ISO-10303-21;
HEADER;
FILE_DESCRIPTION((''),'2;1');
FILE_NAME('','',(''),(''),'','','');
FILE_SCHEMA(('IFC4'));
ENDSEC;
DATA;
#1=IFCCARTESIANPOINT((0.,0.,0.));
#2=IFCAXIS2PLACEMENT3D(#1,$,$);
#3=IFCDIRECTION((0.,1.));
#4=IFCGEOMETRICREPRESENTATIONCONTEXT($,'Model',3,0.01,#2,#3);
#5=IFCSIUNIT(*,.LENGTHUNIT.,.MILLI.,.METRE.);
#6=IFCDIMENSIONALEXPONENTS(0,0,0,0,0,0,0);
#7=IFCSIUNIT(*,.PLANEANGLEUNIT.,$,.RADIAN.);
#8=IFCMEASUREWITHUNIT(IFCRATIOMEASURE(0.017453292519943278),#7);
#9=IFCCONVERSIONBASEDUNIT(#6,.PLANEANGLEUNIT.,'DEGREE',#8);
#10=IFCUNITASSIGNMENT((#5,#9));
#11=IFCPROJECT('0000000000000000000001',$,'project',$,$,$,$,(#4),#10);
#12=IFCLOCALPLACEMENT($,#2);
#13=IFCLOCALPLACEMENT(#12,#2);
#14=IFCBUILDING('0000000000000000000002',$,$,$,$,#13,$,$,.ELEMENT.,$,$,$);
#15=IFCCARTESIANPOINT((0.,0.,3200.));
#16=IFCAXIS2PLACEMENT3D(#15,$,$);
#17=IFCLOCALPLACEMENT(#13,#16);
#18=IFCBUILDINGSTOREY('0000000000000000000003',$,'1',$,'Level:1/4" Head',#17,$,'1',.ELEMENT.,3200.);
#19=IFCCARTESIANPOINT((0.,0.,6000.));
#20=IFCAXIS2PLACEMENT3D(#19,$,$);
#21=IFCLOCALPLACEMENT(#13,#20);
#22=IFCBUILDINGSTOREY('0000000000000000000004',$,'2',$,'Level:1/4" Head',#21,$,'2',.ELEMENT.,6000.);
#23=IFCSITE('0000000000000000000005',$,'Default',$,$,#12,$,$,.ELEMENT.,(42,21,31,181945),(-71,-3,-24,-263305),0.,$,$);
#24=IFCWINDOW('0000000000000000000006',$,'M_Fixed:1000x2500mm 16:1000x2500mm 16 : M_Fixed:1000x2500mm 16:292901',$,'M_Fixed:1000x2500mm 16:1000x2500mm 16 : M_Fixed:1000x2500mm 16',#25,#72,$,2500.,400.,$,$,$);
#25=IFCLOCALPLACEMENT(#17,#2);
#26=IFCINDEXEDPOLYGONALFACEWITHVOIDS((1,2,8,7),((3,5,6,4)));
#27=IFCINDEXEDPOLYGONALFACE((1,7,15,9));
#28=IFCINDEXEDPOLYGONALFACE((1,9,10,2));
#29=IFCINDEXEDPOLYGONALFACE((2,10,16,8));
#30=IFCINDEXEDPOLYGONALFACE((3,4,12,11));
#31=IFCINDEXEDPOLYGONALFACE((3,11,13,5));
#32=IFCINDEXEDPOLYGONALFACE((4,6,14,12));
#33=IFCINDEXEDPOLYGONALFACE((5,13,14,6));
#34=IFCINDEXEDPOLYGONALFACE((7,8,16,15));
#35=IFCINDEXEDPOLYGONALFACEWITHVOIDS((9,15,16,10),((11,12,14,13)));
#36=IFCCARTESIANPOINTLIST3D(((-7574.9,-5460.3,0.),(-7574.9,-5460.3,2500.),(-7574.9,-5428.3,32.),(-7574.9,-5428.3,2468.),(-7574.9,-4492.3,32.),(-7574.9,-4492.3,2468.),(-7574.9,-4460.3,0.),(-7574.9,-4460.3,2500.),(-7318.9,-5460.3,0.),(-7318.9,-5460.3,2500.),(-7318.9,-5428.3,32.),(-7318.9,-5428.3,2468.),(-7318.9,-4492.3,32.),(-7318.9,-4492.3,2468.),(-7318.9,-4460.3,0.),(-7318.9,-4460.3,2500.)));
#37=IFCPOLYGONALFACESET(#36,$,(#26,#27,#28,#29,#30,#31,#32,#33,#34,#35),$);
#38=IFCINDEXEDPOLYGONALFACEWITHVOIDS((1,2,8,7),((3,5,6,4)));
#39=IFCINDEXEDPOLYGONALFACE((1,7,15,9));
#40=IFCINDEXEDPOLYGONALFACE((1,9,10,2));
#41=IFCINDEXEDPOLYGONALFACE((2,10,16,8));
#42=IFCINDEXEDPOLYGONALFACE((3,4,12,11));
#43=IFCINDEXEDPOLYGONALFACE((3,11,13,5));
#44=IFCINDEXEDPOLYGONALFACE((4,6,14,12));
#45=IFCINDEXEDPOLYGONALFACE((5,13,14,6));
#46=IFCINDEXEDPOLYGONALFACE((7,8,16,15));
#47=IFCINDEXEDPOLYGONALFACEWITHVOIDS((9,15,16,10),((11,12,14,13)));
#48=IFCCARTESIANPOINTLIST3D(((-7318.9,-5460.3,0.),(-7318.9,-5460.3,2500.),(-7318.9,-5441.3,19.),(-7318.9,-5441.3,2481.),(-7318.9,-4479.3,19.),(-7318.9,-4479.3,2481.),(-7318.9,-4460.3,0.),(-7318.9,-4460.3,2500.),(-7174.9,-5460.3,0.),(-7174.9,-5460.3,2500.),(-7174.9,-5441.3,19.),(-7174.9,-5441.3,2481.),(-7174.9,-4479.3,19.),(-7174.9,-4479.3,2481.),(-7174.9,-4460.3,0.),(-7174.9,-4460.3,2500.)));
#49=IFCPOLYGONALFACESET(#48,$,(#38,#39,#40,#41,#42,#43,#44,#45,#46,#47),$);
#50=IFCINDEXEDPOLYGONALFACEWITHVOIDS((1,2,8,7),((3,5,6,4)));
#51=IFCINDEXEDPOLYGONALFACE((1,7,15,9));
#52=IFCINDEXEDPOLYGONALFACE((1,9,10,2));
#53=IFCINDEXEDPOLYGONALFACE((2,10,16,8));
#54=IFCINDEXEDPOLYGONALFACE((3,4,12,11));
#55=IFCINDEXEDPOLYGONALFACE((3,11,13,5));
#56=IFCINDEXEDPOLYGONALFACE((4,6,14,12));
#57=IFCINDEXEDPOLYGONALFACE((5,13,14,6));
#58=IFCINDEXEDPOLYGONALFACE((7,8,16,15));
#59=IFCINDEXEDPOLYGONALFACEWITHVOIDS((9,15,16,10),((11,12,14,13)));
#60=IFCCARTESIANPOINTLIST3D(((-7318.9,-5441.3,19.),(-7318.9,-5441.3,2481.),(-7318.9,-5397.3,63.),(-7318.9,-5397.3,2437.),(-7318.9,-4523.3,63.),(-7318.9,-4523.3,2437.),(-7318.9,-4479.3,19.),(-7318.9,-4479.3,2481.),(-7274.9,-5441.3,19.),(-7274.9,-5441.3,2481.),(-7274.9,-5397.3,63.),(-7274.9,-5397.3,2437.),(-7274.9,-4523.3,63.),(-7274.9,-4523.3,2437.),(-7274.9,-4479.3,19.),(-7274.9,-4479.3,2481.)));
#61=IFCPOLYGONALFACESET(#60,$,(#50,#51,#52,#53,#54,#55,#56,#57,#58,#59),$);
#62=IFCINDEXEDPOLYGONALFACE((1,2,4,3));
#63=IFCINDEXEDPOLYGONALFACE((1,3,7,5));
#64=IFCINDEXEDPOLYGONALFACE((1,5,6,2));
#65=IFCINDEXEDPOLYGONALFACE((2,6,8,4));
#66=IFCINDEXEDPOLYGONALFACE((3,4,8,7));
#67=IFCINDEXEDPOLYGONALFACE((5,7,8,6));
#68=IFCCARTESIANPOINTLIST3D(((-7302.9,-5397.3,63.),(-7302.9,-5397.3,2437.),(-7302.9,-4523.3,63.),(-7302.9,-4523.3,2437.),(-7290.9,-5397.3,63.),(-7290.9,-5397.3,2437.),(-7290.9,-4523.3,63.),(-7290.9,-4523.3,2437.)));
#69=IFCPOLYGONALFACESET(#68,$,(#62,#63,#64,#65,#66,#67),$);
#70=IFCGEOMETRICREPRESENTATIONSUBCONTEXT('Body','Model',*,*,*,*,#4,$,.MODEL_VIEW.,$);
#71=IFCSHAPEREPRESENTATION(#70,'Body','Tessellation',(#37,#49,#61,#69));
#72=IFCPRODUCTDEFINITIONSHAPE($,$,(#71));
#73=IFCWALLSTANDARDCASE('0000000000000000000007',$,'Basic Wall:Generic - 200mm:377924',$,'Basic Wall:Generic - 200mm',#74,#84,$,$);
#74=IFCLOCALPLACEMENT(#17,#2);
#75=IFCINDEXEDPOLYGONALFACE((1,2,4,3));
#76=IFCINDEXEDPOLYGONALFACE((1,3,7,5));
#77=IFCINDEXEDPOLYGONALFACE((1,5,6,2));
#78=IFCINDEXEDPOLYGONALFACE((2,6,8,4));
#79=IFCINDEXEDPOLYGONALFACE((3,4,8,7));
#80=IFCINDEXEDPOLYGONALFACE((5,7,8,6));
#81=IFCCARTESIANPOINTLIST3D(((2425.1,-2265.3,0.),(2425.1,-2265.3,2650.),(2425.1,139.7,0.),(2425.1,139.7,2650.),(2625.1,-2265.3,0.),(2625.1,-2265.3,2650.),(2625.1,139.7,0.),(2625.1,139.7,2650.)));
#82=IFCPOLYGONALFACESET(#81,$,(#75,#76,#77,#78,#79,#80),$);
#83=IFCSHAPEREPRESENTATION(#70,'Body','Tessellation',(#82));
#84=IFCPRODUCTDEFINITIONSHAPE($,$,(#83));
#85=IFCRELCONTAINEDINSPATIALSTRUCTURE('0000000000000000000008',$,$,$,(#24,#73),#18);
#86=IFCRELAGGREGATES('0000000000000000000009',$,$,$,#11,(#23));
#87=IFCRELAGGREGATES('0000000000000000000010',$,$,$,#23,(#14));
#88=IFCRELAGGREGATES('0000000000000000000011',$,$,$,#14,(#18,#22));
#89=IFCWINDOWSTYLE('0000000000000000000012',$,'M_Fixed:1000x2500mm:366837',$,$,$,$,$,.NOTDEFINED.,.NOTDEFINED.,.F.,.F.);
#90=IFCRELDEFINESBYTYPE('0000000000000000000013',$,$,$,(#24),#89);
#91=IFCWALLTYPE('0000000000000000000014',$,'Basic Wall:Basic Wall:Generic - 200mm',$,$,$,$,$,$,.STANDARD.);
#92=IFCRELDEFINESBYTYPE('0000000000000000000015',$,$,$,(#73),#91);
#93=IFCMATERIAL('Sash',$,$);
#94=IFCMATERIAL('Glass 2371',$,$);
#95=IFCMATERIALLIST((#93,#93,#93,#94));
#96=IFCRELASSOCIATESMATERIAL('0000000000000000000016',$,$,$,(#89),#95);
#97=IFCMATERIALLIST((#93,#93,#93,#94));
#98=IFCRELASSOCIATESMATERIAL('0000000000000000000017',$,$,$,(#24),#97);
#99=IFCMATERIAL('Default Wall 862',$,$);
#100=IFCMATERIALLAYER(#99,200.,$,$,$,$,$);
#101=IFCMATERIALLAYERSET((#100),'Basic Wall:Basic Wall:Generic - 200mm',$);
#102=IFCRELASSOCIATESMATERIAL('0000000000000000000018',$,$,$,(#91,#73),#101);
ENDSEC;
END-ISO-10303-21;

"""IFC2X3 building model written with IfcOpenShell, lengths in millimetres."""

from ifc_helpers import new_model, entity, si_unit, converted_unit, direction, frame, frame_2d, origin, place, context, subcontext, project, spatial, polyline, rectangle, outline, extrude, source, transform, mapped, material, material_list, layer, layer_set, layer_usage, type_object, type_shapes, element, save


model = new_model("IFC2X3")

# Units and contexts
model_context = context("Model", 3, precision=0.01, world=origin(), true_north=direction((0.0, 1.0)))
body_context = subcontext(model_context, "Body", "Model", "MODEL_VIEW")
ifc_project = project(units=[si_unit("LENGTHUNIT", "METRE", prefix="MILLI"), converted_unit("PLANEANGLEUNIT", "DEGREE", entity("IfcRatioMeasure", 0.017453292519943278), si_unit("PLANEANGLEUNIT", "RADIAN"), dimensions=[0, 0, 0, 0, 0, 0, 0])], contexts=[model_context])

# Site, building, storey
site_placement = place(None, origin())
site = spatial("IfcSite", under=ifc_project, at=site_placement, Name="Default", CompositionType="ELEMENT", RefLatitude=(42, 21, 31, 181945), RefLongitude=(-71, -3, -24, -263305), RefElevation=0.0)
building_placement = place(site_placement, origin())
building = spatial("IfcBuilding", under=site, at=building_placement, CompositionType="ELEMENT")
storey_1_placement = place(building_placement, frame((0.0, 0.0, 3200.0)))
storey_1 = spatial("IfcBuildingStorey", under=building, at=storey_1_placement, Name="1", ObjectType="Level:1/4\" Head", LongName="1", CompositionType="ELEMENT", Elevation=3200.0)

# Shared definitions
ifc_material_1 = material(Name="Default Wall 862")

# Shared definitions
storey_2_placement = place(building_placement, frame((0.0, 0.0, 6000.0)))
storey_2 = spatial("IfcBuildingStorey", under=building, at=storey_2_placement, Name="2", ObjectType="Level:1/4\" Head", LongName="2", CompositionType="ELEMENT", Elevation=6000.0)

# Shared definitions
ifc_material_2 = material(Name="Sash")
ifc_material_3 = material(Name="Glass 2371")

# Window
ifc_material_list_1 = material_list([ifc_material_2, ifc_material_2, ifc_material_2, ifc_material_3])
ifc_material_list_2 = material_list([ifc_material_2, ifc_material_2, ifc_material_2, ifc_material_3])
window_style_1 = type_object("IfcWindowStyle", Name="M_Fixed:1000x2500mm:366837", ConstructionType="NOTDEFINED", OperationType="NOTDEFINED", ParameterTakesPrecedence=False, Sizeable=False, material=ifc_material_list_2)
shared_shape_1 = source(origin(), body_context, "Body", "SweptSolid", [
    extrude(outline(polyline([(-1250.0, -500.0), (1250.0, -500.0), (1250.0, 500.0), (-1250.0, 500.0), (-1250.0, -500.0)]), holes=[polyline([(1218.0, 468.0), (1218.0, -468.0), (-1218.0, -468.0), (-1218.0, 468.0), (1218.0, 468.0)])]), frame((-7574.9, -4960.3, 4450.0), z_axis=(1.0, 0.0, 0.0), x_axis=(0.0, 0.0, -1.0)), (0.0, 0.0, 1.0), 256.0),
    extrude(outline(polyline([(-1250.0, -500.0), (1250.0, -500.0), (1250.0, 500.0), (-1250.0, 500.0), (-1250.0, -500.0)]), holes=[polyline([(1231.0, 481.0), (1231.0, -481.0), (-1231.0, -481.0), (-1231.0, 481.0), (1231.0, 481.0)])]), frame((-7318.9, -4960.3, 4450.0), z_axis=(1.0, 0.0, 0.0), x_axis=(0.0, 0.0, -1.0)), (0.0, 0.0, 1.0), 144.0),
    extrude(outline(polyline([(-1231.0, -481.0), (1231.0, -481.0), (1231.0, 481.0), (-1231.0, 481.0), (-1231.0, -481.0)]), holes=[polyline([(1187.0, 437.0), (1187.0, -437.0), (-1187.0, -437.0), (-1187.0, 437.0), (1187.0, 437.0)])]), frame((-7318.9, -4960.3, 4450.0), z_axis=(1.0, 0.0, 0.0), x_axis=(0.0, 0.0, -1.0)), (0.0, 0.0, 1.0), 44.0),
    extrude(rectangle(XDim=874.0, YDim=12.0, at=frame_2d((0.0, 0.0), x_axis=(1.0, 0.0))), frame((-7296.9, -4960.3, 3263.0), z_axis=(0.0, 0.0, 1.0), x_axis=(0.0, -1.0, 0.0)), (0.0, 0.0, 1.0), 2374.0),
])
type_shapes(window_style_1, [shared_shape_1])
window_1_placement = place(storey_1_placement, frame((0.0, 0.0, -3200.0)))
element("IfcWindow", 1, at=window_1_placement, inside=storey_1, type_object=window_style_1, material=ifc_material_list_1, Name="M_Fixed:1000x2500mm 16:1000x2500mm 16 : M_Fixed:1000x2500mm 16:292901", ObjectType="M_Fixed:1000x2500mm 16:1000x2500mm 16 : M_Fixed:1000x2500mm 16", OverallHeight=2500.0, OverallWidth=400.0, context=body_context, shape_type="MappedRepresentation", body=[
    mapped(shared_shape_1, transform((0.0, 0.0, 0.0), scale=1.0)),
])

# Wall
ifc_layer_1 = layer(ifc_material_1, 200.0)
ifc_layer_set_1 = layer_set([ifc_layer_1], Name="Basic Wall:Basic Wall:Generic - 200mm")
ifc_layer_usage_1 = layer_usage(ifc_layer_set_1, "AXIS2", "NEGATIVE", 100.0)
wall_type_1 = type_object("IfcWallType", Name="Basic Wall:Basic Wall:Generic - 200mm", PredefinedType="STANDARD", material=ifc_layer_set_1)
wall_1_placement = place(storey_1_placement, frame((2525.1, 139.7, 0.0), z_axis=(0.0, 0.0, 1.0), x_axis=(0.0, -1.0, 0.0)))
element("IfcWallStandardCase", 2, at=wall_1_placement, inside=storey_1, type_object=wall_type_1, material=ifc_layer_usage_1, Name="Basic Wall:Generic - 200mm:377924", ObjectType="Basic Wall:Generic - 200mm", context=body_context, shape_type="SweptSolid", body=[
    extrude(rectangle(XDim=2405.0, YDim=200.0, at=frame_2d((1202.5, 0.0), x_axis=(-1.0, 0.0))), origin(), (0.0, 0.0, 1.0), 2650.0),
])

save(model, "model.ifc")
